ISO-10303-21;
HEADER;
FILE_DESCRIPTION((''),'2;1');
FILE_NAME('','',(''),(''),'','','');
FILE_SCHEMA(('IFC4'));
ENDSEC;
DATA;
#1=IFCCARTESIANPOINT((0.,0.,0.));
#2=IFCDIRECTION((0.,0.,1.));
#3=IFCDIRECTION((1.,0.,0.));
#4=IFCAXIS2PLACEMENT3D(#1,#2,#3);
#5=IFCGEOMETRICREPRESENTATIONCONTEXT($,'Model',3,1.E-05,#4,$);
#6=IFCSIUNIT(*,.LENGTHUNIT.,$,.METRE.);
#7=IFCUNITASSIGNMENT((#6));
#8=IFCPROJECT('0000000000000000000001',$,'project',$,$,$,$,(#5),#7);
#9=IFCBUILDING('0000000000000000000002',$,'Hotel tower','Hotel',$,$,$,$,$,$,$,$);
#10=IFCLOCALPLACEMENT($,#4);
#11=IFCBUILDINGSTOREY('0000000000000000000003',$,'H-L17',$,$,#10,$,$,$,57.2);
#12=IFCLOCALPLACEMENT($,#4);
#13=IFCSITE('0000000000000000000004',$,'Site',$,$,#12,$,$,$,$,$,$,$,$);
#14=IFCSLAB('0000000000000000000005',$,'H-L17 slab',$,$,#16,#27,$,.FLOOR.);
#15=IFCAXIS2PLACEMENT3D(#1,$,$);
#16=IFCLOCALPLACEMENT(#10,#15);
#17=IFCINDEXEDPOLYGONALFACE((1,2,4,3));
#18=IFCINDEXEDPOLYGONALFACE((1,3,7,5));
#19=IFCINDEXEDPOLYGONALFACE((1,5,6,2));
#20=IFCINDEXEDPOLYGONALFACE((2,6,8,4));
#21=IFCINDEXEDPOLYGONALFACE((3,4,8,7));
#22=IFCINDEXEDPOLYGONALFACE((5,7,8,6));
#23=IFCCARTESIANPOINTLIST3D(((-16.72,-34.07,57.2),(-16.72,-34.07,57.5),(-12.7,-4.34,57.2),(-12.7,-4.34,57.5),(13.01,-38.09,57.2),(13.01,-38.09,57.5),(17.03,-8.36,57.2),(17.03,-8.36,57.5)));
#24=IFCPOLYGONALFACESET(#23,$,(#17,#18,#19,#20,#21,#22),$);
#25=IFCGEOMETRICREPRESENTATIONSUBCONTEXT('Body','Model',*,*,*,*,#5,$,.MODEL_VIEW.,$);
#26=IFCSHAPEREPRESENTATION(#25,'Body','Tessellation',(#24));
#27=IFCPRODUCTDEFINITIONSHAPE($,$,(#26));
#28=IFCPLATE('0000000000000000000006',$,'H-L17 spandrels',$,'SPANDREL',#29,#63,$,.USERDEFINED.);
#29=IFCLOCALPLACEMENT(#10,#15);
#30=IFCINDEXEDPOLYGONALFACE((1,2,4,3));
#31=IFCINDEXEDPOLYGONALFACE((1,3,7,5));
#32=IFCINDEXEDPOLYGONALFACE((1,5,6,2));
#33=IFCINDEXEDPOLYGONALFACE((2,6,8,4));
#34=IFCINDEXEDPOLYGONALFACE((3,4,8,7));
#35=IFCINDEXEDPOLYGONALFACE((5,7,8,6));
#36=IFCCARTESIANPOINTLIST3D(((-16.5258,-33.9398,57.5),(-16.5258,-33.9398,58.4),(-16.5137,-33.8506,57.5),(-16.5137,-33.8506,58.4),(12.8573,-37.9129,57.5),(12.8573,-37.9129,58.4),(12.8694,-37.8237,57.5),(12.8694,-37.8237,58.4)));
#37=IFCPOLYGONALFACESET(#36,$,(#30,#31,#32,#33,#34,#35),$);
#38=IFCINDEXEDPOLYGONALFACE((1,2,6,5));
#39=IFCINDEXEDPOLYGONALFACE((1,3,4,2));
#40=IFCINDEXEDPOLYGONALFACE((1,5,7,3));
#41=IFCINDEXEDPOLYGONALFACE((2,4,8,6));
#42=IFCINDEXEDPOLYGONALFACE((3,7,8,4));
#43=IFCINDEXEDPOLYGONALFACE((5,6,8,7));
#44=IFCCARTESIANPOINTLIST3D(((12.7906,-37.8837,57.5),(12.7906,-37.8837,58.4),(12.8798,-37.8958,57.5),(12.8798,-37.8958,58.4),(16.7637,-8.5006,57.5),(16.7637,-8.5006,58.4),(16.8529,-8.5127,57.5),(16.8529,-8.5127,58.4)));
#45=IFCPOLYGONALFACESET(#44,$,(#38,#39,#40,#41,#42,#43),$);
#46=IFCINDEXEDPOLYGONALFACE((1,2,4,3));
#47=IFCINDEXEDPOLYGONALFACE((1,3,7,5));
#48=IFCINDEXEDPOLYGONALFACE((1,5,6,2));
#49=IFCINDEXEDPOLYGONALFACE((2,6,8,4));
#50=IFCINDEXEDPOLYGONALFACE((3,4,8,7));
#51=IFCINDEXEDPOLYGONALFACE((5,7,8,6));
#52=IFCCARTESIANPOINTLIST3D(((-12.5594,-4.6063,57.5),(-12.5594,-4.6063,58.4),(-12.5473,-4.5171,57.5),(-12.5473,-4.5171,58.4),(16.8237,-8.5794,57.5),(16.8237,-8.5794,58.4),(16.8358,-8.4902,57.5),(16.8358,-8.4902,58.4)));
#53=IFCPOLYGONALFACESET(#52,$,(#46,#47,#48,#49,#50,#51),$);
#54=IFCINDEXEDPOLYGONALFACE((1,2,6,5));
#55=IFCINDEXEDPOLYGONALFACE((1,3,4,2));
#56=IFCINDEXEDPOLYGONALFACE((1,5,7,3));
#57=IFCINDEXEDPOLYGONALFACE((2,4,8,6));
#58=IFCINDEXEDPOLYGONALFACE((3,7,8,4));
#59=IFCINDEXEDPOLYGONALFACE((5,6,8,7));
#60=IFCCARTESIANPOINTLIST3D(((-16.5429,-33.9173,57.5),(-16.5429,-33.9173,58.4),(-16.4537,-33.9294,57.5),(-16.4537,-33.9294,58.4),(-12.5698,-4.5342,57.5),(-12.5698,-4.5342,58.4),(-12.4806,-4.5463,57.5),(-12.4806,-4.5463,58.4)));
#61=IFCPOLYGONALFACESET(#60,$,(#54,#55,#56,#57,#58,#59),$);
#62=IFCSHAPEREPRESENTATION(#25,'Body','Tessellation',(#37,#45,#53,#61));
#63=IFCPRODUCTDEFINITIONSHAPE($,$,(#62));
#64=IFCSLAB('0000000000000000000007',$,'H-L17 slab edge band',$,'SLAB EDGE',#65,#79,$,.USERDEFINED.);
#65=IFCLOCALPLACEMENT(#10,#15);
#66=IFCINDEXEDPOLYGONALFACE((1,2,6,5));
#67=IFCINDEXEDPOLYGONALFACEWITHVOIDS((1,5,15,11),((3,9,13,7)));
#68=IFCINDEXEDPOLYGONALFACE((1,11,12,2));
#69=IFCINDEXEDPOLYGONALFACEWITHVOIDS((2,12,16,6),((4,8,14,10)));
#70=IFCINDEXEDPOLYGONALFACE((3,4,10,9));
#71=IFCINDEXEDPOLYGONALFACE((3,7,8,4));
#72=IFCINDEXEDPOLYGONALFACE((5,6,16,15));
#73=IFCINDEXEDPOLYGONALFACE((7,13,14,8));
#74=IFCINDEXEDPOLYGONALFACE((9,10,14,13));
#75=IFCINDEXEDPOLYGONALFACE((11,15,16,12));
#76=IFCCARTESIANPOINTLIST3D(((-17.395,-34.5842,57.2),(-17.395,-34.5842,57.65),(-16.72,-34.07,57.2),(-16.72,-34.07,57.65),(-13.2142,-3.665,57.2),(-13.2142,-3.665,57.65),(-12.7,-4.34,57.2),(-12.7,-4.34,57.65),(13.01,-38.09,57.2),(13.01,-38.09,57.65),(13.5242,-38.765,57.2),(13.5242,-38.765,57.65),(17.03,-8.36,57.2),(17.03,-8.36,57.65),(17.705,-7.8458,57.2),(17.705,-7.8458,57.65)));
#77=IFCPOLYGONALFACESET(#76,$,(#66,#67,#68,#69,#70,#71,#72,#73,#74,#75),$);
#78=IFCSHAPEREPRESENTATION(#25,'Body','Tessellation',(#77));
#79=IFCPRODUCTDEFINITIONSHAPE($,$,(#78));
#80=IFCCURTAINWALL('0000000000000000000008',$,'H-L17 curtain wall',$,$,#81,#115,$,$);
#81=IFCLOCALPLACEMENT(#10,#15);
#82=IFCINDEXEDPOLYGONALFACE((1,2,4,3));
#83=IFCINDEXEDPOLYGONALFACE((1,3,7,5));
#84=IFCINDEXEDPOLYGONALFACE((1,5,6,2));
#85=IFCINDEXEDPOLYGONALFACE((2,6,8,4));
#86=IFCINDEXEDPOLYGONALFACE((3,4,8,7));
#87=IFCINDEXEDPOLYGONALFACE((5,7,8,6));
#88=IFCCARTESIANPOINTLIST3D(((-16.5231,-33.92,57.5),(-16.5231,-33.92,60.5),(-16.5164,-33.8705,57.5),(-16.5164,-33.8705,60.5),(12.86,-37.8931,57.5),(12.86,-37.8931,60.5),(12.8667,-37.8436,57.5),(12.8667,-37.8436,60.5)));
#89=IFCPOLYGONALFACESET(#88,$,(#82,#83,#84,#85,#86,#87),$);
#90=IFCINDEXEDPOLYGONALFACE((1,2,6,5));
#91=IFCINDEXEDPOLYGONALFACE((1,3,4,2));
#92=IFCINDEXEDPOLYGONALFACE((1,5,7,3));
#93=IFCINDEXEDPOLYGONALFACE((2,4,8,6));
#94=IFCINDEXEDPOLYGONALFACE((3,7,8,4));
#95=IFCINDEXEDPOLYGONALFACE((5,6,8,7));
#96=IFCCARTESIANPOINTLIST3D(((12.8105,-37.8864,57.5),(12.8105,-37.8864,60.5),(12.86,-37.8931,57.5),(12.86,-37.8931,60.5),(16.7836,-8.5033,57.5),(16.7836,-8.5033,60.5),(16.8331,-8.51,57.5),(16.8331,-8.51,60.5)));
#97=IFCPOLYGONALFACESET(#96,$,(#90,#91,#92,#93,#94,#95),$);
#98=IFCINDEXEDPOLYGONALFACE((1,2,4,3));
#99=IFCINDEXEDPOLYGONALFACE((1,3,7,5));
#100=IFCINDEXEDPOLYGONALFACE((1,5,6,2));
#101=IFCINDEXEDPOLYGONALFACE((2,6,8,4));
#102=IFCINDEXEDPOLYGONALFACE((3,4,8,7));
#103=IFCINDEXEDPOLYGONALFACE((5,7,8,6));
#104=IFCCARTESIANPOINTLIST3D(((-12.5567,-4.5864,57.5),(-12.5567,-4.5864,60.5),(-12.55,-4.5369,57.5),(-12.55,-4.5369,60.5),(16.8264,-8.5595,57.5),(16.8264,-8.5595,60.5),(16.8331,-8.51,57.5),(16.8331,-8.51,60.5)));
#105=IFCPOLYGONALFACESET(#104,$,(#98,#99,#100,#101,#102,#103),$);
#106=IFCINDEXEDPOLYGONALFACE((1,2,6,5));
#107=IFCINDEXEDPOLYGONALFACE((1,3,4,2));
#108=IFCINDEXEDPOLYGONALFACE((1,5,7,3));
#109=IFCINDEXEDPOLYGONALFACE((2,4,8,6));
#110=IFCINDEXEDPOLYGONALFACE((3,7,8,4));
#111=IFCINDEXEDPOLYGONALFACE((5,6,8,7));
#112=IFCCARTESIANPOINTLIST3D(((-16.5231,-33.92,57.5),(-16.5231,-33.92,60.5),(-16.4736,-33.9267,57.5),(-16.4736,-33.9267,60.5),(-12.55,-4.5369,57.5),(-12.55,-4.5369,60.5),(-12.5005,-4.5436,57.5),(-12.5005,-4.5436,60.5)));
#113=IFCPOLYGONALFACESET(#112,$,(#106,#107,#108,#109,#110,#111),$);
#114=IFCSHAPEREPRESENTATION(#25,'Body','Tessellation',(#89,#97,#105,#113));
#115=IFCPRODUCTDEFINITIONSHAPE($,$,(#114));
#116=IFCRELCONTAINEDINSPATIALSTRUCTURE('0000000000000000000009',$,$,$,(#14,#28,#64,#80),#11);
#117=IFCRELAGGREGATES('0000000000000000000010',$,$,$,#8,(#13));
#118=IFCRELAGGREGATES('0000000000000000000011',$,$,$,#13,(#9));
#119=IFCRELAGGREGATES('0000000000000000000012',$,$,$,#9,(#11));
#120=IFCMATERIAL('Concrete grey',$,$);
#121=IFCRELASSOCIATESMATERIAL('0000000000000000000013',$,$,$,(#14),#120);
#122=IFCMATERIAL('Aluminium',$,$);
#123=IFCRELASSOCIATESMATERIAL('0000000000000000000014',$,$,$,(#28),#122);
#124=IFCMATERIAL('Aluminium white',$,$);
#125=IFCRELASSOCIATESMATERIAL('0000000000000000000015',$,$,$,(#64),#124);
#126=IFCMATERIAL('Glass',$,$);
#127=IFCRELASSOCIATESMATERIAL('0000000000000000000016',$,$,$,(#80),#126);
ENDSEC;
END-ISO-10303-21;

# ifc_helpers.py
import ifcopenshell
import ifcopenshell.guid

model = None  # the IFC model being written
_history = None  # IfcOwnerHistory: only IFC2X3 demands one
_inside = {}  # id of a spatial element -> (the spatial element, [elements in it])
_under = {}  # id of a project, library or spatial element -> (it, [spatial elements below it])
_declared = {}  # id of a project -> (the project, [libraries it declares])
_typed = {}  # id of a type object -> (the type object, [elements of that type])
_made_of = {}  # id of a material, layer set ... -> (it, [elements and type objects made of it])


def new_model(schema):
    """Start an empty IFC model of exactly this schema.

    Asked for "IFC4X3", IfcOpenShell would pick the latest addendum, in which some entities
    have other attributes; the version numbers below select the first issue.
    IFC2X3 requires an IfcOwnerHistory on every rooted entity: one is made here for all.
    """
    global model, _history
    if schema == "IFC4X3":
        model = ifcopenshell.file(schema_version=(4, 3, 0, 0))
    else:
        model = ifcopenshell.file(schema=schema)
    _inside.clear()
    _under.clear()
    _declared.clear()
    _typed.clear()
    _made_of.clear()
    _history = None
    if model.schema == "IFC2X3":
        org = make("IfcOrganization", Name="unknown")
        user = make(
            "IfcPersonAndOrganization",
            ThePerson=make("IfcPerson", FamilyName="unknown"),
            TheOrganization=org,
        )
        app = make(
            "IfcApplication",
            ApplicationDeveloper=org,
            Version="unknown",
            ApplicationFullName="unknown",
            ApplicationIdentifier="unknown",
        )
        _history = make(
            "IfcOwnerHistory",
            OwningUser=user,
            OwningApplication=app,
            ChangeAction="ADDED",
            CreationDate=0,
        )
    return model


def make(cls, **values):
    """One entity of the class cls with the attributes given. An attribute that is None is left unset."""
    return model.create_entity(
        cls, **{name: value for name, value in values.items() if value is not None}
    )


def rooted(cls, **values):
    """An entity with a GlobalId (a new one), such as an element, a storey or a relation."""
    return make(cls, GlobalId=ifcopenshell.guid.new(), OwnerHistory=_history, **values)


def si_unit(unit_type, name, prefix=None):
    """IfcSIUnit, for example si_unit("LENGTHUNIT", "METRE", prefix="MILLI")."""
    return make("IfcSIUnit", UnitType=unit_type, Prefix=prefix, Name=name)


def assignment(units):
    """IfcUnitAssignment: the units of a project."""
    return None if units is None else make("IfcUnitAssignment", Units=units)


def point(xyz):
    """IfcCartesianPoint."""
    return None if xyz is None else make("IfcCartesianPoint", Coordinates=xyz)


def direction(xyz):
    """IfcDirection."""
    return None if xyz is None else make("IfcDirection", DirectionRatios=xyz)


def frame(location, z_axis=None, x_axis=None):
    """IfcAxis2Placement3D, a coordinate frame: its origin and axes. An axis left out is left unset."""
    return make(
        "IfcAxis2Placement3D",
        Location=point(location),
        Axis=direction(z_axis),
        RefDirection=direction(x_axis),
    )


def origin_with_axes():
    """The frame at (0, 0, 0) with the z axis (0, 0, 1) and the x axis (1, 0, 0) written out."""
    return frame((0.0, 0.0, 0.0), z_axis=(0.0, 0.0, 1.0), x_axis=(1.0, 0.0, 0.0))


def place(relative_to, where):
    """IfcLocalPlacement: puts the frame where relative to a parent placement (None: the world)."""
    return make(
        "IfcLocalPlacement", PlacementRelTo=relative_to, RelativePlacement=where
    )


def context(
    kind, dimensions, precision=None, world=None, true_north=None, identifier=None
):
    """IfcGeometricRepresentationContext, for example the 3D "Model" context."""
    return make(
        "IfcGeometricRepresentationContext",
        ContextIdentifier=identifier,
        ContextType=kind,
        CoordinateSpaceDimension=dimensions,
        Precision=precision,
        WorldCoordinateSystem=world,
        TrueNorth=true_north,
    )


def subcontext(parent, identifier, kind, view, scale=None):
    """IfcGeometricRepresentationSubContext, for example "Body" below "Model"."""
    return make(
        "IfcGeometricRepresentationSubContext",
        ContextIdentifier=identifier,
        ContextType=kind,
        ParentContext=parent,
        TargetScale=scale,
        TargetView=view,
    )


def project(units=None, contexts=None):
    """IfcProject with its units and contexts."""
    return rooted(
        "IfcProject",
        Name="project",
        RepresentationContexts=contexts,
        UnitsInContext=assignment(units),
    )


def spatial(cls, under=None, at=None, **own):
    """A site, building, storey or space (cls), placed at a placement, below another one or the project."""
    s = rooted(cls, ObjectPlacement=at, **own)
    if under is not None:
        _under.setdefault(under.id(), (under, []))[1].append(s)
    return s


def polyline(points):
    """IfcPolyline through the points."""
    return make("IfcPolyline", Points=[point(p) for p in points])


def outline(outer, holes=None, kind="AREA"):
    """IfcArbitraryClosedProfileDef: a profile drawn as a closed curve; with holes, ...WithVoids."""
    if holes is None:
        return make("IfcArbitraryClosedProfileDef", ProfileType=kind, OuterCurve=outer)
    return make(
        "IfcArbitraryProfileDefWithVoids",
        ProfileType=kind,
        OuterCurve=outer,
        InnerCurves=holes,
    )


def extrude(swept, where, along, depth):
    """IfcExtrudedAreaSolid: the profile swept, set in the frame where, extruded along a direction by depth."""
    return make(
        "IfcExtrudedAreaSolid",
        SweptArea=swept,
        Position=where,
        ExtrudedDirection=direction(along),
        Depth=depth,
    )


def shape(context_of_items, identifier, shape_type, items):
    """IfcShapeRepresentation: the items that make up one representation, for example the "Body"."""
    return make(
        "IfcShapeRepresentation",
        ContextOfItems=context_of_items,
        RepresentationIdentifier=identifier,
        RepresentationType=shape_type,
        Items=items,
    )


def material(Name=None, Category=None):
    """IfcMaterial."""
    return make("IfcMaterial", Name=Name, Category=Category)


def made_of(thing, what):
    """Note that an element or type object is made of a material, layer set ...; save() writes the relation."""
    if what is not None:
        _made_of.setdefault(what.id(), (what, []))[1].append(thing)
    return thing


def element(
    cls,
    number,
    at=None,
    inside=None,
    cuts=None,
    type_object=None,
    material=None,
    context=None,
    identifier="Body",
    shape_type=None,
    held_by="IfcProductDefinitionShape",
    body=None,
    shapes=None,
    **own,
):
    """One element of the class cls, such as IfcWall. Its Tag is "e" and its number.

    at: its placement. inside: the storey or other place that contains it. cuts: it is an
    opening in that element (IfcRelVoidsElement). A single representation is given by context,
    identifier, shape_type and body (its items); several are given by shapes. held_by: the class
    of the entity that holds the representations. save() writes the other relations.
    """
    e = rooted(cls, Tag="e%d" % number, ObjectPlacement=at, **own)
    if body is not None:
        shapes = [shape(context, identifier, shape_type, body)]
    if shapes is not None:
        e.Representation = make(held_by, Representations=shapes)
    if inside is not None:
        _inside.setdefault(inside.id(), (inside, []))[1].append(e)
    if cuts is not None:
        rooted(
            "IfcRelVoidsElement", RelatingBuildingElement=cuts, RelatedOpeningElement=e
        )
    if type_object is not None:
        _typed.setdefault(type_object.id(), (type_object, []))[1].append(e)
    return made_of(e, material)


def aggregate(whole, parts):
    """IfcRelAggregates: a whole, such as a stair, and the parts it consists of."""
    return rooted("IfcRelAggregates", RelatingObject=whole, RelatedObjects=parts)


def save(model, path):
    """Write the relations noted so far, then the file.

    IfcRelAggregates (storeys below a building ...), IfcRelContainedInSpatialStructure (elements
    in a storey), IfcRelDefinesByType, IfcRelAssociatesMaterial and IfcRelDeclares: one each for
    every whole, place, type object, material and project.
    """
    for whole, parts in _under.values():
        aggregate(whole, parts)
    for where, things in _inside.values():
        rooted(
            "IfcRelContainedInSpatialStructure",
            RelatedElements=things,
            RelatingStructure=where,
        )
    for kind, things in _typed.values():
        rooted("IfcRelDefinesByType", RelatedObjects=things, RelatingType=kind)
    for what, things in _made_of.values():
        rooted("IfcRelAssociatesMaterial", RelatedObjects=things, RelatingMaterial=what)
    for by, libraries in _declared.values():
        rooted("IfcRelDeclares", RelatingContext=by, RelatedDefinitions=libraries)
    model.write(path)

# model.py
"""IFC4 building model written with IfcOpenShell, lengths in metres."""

from ifc_helpers import new_model, si_unit, frame, origin_with_axes, place, context, subcontext, project, spatial, polyline, outline, extrude, material, element, save


model = new_model("IFC4")

# Units and contexts
model_context = context("Model", 3, precision=1e-05, world=origin_with_axes())
body_context = subcontext(model_context, "Body", "Model", "MODEL_VIEW")
ifc_project = project(units=[si_unit("LENGTHUNIT", "METRE")], contexts=[model_context])

# Site, building, storey
site_placement = place(None, origin_with_axes())
site = spatial("IfcSite", under=ifc_project, at=site_placement, Name="Site")
building = spatial("IfcBuilding", under=site, Name="Hotel tower", Description="Hotel")
storey_placement = place(None, origin_with_axes())
storey = spatial("IfcBuildingStorey", under=building, at=storey_placement, Name="H-L17", Elevation=57.2)

# Shared definitions
ifc_material_1 = material(Name="Aluminium")

# Slab
ifc_material_2 = material(Name="Concrete grey")
slab_1_placement = place(storey_placement, origin_with_axes())
element("IfcSlab", 1, at=slab_1_placement, inside=storey, material=ifc_material_2, Name="H-L17 slab", PredefinedType="FLOOR", context=body_context, shape_type="SweptSolid", body=[
    extrude(outline(polyline([(-16.72, -34.07), (13.01, -38.09), (17.03, -8.36), (-12.7, -4.34), (-16.72, -34.07)])), frame((0.0, 0.0, 57.2), z_axis=(0.0, 0.0, 1.0), x_axis=(1.0, 0.0, 0.0)), (0.0, 0.0, 1.0), 0.3),
])

# Plate
plate_placement = place(storey_placement, origin_with_axes())
element("IfcPlate", 2, at=plate_placement, inside=storey, material=ifc_material_1, Name="H-L17 spandrels", ObjectType="SPANDREL", PredefinedType="USERDEFINED", context=body_context, shape_type="SweptSolid", body=[
    extrude(outline(polyline([(-16.5258, -33.9398), (12.8573, -37.9129), (12.8694, -37.8237), (-16.5137, -33.8506), (-16.5258, -33.9398)])), frame((0.0, 0.0, 57.5), z_axis=(0.0, 0.0, 1.0), x_axis=(1.0, 0.0, 0.0)), (0.0, 0.0, 1.0), 0.9),
    extrude(outline(polyline([(12.8798, -37.8958), (16.8529, -8.5127), (16.7637, -8.5006), (12.7906, -37.8837), (12.8798, -37.8958)])), frame((0.0, 0.0, 57.5), z_axis=(0.0, 0.0, 1.0), x_axis=(1.0, 0.0, 0.0)), (0.0, 0.0, 1.0), 0.9),
    extrude(outline(polyline([(16.8358, -8.4902), (-12.5473, -4.5171), (-12.5594, -4.6063), (16.8237, -8.5794), (16.8358, -8.4902)])), frame((0.0, 0.0, 57.5), z_axis=(0.0, 0.0, 1.0), x_axis=(1.0, 0.0, 0.0)), (0.0, 0.0, 1.0), 0.9),
    extrude(outline(polyline([(-12.5698, -4.5342), (-16.5429, -33.9173), (-16.4537, -33.9294), (-12.4806, -4.5463), (-12.5698, -4.5342)])), frame((0.0, 0.0, 57.5), z_axis=(0.0, 0.0, 1.0), x_axis=(1.0, 0.0, 0.0)), (0.0, 0.0, 1.0), 0.9),
])

# Slab
ifc_material_3 = material(Name="Aluminium white")
slab_2_placement = place(storey_placement, origin_with_axes())
element("IfcSlab", 3, at=slab_2_placement, inside=storey, material=ifc_material_3, Name="H-L17 slab edge band", ObjectType="SLAB EDGE", PredefinedType="USERDEFINED", context=body_context, shape_type="SweptSolid", body=[
    extrude(outline(polyline([(-17.395, -34.5842), (13.5242, -38.765), (17.705, -7.8458), (-13.2142, -3.665), (-17.395, -34.5842)]), holes=[polyline([(-16.72, -34.07), (13.01, -38.09), (17.03, -8.36), (-12.7, -4.34), (-16.72, -34.07)])]), frame((0.0, 0.0, 57.2), z_axis=(0.0, 0.0, 1.0), x_axis=(1.0, 0.0, 0.0)), (0.0, 0.0, 1.0), 0.45),
])

# Curtain wall
ifc_material_4 = material(Name="Glass")
curtain_wall_placement = place(storey_placement, origin_with_axes())
element("IfcCurtainWall", 4, at=curtain_wall_placement, inside=storey, material=ifc_material_4, Name="H-L17 curtain wall", context=body_context, shape_type="SweptSolid", body=[
    extrude(outline(polyline([(-16.5231, -33.92), (12.86, -37.8931), (12.8667, -37.8436), (-16.5164, -33.8705), (-16.5231, -33.92)])), frame((0.0, 0.0, 57.5), z_axis=(0.0, 0.0, 1.0), x_axis=(1.0, 0.0, 0.0)), (0.0, 0.0, 1.0), 3.0),
    extrude(outline(polyline([(12.86, -37.8931), (16.8331, -8.51), (16.7836, -8.5033), (12.8105, -37.8864), (12.86, -37.8931)])), frame((0.0, 0.0, 57.5), z_axis=(0.0, 0.0, 1.0), x_axis=(1.0, 0.0, 0.0)), (0.0, 0.0, 1.0), 3.0),
    extrude(outline(polyline([(16.8331, -8.51), (-12.55, -4.5369), (-12.5567, -4.5864), (16.8264, -8.5595), (16.8331, -8.51)])), frame((0.0, 0.0, 57.5), z_axis=(0.0, 0.0, 1.0), x_axis=(1.0, 0.0, 0.0)), (0.0, 0.0, 1.0), 3.0),
    extrude(outline(polyline([(-12.55, -4.5369), (-16.5231, -33.92), (-16.4736, -33.9267), (-12.5005, -4.5436), (-12.55, -4.5369)])), frame((0.0, 0.0, 57.5), z_axis=(0.0, 0.0, 1.0), x_axis=(1.0, 0.0, 0.0)), (0.0, 0.0, 1.0), 3.0),
])

save(model, "model.ifc")
